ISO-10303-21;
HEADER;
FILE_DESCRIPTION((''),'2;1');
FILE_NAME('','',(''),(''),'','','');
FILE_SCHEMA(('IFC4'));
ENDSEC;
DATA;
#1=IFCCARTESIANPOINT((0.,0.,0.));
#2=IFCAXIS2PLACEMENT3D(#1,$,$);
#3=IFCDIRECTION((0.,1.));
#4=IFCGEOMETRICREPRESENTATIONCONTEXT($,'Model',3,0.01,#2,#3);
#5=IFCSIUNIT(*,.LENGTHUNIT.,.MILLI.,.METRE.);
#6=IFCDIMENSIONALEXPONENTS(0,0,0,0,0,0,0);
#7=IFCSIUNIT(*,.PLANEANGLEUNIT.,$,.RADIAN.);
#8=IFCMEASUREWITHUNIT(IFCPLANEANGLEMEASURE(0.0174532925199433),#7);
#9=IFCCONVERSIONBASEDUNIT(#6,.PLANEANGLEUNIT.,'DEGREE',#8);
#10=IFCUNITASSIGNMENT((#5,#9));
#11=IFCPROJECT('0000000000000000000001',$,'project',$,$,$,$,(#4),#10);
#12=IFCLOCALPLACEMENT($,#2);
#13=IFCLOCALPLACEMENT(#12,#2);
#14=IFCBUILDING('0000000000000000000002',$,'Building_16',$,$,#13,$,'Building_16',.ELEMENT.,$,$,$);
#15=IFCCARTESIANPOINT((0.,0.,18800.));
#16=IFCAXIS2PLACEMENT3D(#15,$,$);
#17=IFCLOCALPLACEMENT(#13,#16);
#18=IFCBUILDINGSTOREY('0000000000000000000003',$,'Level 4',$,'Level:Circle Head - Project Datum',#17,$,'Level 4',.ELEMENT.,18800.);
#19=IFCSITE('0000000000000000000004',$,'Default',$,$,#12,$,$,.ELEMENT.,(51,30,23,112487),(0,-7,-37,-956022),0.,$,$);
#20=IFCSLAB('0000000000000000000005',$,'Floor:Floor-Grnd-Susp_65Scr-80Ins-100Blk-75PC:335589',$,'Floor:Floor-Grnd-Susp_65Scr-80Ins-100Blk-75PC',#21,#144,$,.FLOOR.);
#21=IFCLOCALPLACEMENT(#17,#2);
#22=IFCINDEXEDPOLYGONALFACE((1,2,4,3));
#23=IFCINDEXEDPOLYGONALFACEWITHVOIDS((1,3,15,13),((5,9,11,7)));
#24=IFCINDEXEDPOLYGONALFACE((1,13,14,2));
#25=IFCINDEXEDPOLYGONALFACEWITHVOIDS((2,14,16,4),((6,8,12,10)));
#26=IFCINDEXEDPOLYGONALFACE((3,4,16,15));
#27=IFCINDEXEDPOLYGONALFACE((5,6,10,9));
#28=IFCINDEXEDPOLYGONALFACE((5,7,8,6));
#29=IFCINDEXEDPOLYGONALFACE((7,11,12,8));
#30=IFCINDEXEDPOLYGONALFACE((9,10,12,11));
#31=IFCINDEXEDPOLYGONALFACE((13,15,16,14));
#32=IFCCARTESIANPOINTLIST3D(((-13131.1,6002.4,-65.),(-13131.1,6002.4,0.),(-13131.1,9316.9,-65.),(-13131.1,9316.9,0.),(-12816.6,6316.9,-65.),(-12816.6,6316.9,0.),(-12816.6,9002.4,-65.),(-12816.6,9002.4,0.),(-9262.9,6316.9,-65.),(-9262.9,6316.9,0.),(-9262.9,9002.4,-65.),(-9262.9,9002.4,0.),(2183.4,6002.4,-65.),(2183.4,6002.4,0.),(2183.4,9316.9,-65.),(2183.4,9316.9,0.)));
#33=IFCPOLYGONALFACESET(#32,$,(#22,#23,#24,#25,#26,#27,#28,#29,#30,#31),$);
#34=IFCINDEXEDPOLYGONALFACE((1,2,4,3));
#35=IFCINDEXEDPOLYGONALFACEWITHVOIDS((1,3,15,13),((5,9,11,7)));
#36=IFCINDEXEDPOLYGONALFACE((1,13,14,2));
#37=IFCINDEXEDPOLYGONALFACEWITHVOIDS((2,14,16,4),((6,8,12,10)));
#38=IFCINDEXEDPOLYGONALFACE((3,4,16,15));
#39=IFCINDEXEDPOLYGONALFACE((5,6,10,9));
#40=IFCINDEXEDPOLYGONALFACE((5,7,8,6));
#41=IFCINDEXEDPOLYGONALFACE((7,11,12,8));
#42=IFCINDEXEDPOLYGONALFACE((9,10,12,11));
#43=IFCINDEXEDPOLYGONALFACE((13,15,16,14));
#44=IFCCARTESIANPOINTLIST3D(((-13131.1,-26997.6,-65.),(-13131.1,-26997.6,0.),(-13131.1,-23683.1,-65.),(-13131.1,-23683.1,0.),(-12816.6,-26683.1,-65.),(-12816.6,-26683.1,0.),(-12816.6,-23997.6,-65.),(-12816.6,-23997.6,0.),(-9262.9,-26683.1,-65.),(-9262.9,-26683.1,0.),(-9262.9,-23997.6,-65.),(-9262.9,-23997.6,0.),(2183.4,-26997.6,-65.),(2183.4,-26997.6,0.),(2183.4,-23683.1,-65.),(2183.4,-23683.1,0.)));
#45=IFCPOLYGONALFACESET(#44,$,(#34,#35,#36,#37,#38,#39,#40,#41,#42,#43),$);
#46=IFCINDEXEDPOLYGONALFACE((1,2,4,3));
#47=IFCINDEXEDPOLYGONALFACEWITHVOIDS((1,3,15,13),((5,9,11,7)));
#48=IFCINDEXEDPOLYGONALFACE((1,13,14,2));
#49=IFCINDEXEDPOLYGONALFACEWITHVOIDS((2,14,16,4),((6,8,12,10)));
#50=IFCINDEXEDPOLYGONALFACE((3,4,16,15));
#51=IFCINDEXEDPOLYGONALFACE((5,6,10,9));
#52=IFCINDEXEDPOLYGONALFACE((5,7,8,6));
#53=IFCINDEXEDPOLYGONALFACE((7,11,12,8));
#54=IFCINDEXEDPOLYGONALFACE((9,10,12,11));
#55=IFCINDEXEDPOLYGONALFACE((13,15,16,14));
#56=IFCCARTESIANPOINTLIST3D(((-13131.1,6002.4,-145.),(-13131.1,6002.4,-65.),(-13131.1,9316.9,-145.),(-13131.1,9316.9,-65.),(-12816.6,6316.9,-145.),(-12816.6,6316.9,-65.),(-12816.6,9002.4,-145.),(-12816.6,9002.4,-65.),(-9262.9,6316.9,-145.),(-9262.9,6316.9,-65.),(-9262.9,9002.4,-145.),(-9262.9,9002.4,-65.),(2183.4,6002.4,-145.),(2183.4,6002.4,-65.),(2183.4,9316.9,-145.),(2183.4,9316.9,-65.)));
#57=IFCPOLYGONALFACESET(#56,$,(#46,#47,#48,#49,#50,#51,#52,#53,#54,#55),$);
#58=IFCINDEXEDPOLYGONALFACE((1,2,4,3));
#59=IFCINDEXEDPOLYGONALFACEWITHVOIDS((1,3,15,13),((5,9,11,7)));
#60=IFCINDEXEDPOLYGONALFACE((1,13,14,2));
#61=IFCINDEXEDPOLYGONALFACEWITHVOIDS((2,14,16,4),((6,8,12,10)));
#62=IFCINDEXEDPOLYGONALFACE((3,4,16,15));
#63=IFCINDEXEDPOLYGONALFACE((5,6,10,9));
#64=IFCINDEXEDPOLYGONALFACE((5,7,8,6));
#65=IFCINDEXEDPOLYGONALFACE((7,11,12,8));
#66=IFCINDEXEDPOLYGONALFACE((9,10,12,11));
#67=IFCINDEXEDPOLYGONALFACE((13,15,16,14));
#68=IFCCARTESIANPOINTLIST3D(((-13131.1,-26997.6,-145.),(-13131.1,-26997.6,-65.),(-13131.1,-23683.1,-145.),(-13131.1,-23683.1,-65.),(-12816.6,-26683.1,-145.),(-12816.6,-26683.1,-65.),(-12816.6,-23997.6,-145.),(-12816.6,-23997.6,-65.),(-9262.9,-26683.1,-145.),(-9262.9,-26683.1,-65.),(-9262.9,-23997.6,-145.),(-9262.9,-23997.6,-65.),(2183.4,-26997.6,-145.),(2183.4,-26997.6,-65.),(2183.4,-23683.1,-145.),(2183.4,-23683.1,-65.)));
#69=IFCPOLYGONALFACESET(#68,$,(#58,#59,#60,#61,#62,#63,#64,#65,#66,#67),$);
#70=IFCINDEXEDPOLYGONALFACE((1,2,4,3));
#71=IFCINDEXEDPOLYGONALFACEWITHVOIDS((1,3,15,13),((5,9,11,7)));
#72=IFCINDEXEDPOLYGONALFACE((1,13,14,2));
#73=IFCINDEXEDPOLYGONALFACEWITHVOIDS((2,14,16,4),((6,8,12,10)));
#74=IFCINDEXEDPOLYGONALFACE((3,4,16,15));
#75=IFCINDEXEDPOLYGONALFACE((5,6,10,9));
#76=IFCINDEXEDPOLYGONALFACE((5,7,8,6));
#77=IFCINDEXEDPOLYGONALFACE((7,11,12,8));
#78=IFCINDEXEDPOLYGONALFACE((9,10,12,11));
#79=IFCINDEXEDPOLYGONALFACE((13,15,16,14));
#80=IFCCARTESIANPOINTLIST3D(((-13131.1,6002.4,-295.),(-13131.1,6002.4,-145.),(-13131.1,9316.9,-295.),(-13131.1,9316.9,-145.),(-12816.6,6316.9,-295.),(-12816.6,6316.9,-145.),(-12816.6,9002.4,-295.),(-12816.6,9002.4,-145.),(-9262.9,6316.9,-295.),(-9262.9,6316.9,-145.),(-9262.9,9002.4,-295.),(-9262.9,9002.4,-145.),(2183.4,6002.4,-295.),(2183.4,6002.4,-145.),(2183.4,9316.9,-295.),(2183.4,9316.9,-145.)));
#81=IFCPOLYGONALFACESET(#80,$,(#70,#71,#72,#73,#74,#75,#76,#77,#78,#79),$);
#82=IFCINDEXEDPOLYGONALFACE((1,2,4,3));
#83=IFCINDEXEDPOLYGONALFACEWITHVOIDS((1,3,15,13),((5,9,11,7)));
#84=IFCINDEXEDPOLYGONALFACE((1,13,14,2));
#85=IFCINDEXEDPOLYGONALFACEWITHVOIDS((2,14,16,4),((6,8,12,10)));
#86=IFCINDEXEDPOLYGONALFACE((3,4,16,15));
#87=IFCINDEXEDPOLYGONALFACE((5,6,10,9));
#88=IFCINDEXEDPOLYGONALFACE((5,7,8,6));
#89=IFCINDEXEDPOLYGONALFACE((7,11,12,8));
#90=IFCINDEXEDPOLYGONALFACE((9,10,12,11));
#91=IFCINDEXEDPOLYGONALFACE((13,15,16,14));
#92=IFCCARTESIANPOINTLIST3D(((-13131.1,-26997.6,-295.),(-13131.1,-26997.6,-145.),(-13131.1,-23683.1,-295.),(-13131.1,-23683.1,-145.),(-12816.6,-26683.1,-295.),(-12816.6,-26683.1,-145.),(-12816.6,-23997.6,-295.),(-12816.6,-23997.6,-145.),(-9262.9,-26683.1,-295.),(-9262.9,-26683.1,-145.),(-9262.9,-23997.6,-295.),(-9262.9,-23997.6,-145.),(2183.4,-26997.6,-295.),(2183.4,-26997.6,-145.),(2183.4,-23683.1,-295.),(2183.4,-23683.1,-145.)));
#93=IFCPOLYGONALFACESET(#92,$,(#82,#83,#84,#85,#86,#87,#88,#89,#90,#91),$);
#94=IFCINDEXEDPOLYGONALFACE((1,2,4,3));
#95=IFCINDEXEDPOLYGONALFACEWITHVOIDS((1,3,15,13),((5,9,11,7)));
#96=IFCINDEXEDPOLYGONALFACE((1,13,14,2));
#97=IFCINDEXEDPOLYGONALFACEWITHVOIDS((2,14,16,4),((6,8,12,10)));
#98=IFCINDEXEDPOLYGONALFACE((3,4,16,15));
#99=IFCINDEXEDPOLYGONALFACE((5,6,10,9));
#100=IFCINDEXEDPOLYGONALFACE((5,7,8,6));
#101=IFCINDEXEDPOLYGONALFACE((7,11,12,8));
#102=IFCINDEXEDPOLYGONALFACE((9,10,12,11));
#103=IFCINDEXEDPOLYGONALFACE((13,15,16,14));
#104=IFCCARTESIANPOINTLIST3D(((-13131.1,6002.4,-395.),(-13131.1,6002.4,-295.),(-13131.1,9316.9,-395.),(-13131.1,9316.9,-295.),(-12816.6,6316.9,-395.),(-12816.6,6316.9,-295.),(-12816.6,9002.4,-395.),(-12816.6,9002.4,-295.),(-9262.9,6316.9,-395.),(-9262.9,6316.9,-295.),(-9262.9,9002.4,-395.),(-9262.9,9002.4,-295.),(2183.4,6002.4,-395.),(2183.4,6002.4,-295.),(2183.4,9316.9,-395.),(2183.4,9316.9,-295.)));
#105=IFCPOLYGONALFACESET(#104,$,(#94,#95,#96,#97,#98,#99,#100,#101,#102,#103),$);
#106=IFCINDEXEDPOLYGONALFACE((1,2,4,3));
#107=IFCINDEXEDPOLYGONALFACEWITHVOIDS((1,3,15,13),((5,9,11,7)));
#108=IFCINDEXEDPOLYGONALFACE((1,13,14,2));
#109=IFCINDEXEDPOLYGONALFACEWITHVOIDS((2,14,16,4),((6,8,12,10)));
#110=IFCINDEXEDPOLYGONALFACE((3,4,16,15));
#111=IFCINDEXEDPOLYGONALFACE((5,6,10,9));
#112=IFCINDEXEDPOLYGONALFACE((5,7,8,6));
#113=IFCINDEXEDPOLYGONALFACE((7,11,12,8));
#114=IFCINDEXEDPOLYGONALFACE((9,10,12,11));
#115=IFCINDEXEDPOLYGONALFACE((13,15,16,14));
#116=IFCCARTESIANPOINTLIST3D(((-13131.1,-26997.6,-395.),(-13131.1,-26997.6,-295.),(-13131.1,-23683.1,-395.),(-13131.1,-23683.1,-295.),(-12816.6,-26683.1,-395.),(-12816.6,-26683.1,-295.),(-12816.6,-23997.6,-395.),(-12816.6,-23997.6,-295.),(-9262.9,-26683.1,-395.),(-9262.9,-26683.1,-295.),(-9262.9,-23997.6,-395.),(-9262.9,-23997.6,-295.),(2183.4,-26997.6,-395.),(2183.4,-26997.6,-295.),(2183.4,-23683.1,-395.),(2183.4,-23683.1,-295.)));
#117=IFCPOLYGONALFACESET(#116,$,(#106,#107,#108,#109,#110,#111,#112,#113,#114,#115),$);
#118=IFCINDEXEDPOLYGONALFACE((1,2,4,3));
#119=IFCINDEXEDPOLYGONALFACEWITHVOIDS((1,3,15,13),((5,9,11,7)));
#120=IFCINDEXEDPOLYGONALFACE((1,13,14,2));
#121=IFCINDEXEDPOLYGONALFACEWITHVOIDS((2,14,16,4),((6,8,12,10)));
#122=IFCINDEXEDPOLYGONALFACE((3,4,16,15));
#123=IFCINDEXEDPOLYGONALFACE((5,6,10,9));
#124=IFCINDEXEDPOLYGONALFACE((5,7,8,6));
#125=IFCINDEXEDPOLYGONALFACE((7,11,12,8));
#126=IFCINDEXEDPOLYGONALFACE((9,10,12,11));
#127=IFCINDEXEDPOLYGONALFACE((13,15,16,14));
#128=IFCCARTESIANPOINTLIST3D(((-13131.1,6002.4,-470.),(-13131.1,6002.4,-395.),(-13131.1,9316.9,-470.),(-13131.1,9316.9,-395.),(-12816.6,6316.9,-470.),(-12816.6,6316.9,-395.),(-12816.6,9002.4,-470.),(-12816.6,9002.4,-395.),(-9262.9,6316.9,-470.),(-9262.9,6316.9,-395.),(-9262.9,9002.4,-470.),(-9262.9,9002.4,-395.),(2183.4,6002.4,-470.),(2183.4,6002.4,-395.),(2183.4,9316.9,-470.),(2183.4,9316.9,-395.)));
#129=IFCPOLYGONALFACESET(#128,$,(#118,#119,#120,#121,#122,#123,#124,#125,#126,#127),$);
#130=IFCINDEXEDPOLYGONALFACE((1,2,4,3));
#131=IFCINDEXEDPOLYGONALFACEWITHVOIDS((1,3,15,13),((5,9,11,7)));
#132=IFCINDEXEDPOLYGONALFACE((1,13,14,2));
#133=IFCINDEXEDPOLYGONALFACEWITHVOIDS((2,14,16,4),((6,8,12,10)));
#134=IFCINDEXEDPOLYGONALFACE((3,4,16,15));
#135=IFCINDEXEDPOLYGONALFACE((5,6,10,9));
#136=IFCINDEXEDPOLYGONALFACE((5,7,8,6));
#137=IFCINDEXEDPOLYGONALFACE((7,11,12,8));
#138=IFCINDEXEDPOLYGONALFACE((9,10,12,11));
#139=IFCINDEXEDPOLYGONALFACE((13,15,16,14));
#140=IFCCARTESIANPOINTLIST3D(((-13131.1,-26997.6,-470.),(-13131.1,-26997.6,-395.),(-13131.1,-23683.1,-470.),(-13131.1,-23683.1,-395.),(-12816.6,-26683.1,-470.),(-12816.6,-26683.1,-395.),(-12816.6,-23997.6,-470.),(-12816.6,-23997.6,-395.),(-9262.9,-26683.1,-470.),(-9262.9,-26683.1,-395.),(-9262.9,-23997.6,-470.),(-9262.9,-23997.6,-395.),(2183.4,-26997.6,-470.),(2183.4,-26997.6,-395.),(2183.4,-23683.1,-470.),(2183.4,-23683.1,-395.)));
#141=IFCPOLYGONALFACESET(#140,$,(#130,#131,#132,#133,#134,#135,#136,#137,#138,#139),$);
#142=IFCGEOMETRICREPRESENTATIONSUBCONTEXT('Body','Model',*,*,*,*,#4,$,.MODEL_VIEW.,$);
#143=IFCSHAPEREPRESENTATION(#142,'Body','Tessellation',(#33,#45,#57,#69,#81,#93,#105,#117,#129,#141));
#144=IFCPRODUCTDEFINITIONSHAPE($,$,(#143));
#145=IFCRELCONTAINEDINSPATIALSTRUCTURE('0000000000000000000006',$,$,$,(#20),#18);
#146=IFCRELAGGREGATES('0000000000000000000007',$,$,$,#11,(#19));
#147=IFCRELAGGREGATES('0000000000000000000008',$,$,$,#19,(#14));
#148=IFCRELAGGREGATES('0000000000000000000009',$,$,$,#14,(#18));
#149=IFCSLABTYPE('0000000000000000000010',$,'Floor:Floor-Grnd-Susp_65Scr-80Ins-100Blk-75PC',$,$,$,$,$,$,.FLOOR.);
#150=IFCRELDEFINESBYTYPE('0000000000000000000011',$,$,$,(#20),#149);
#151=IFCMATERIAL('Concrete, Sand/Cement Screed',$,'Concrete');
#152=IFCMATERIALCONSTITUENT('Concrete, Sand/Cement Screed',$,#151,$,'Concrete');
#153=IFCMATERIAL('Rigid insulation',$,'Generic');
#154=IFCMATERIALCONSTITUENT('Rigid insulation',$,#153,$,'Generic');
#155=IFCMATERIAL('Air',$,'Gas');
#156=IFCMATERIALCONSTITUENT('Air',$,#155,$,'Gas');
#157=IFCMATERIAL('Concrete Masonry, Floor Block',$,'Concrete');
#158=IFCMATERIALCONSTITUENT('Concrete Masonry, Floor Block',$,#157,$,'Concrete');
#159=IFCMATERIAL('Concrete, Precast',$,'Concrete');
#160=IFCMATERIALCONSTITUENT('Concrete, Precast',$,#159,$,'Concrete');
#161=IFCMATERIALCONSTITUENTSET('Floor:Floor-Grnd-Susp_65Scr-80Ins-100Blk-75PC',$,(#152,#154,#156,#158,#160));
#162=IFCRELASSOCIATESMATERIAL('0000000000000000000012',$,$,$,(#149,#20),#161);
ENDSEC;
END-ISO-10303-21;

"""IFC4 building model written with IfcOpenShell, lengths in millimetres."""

from ifc_helpers import new_model, entity, si_unit, converted_unit, direction, frame, origin, place, context, subcontext, project, spatial, indexed_curve, outline, extrude, material, constituent, constituent_set, type_object, element, save


model = new_model("IFC4")

# Units and contexts
model_context = context("Model", 3, precision=0.01, world=origin(), true_north=direction((0.0, 1.0)))
body_context = subcontext(model_context, "Body", "Model", "MODEL_VIEW")
ifc_project = project(units=[si_unit("LENGTHUNIT", "METRE", prefix="MILLI"), converted_unit("PLANEANGLEUNIT", "DEGREE", entity("IfcPlaneAngleMeasure", 0.0174532925199433), si_unit("PLANEANGLEUNIT", "RADIAN"), dimensions=[0, 0, 0, 0, 0, 0, 0])], contexts=[model_context])

# Site, building, storey
site_placement = place(None, origin())
site = spatial("IfcSite", under=ifc_project, at=site_placement, Name="Default", CompositionType="ELEMENT", RefLatitude=(51, 30, 23, 112487), RefLongitude=(0, -7, -37, -956022), RefElevation=0.0)
building_placement = place(site_placement, origin())
building = spatial("IfcBuilding", under=site, at=building_placement, Name="Building_16", LongName="Building_16", CompositionType="ELEMENT")
storey_placement = place(building_placement, frame((0.0, 0.0, 18800.0)))
storey = spatial("IfcBuildingStorey", under=building, at=storey_placement, Name="Level 4", ObjectType="Level:Circle Head - Project Datum", LongName="Level 4", CompositionType="ELEMENT", Elevation=18800.0)

# Slab, openings
ifc_material_1 = material(Name="Concrete, Sand/Cement Screed", Category="Concrete")
ifc_constituent_1 = constituent(ifc_material_1, Name="Concrete, Sand/Cement Screed", Category="Concrete")
ifc_material_2 = material(Name="Rigid insulation", Category="Generic")
ifc_constituent_2 = constituent(ifc_material_2, Name="Rigid insulation", Category="Generic")
ifc_material_3 = material(Name="Air", Category="Gas")
ifc_constituent_3 = constituent(ifc_material_3, Name="Air", Category="Gas")
ifc_material_4 = material(Name="Concrete Masonry, Floor Block", Category="Concrete")
ifc_constituent_4 = constituent(ifc_material_4, Name="Concrete Masonry, Floor Block", Category="Concrete")
ifc_material_5 = material(Name="Concrete, Precast", Category="Concrete")
ifc_constituent_5 = constituent(ifc_material_5, Name="Concrete, Precast", Category="Concrete")
ifc_constituent_set_1 = constituent_set(constituents=[ifc_constituent_1, ifc_constituent_2, ifc_constituent_3, ifc_constituent_4, ifc_constituent_5], Name="Floor:Floor-Grnd-Susp_65Scr-80Ins-100Blk-75PC")
slab_type = type_object("IfcSlabType", Name="Floor:Floor-Grnd-Susp_65Scr-80Ins-100Blk-75PC", PredefinedType="FLOOR", material=ifc_constituent_set_1)
slab_placement = place(storey_placement, origin())
slab = element("IfcSlab", 1, at=slab_placement, inside=storey, type_object=slab_type, material=ifc_constituent_set_1, Name="Floor:Floor-Grnd-Susp_65Scr-80Ins-100Blk-75PC:335589", ObjectType="Floor:Floor-Grnd-Susp_65Scr-80Ins-100Blk-75PC", PredefinedType="FLOOR", context=body_context, shape_type="SweptSolid", body=[
    extrude(outline(indexed_curve([(-7657.2, -1657.3), (7657.2, -1657.3), (7657.2, 1657.3), (-7657.2, 1657.3), (-7657.2, -1657.3)], self_intersect=False), holes=[indexed_curve([(3789.0, -1342.8), (3789.0, 1342.8), (7342.8, 1342.8), (7342.8, -1342.8), (3789.0, -1342.8)], self_intersect=False)]), frame((-5473.9, 7659.6, -65.0), z_axis=(0.0, 0.0, 1.0), x_axis=(-1.0, 0.0, 0.0)), (0.0, 0.0, 1.0), 65.0),
    extrude(outline(indexed_curve([(-7657.2, -1657.2), (7657.2, -1657.2), (7657.2, 1657.2), (-7657.2, 1657.2), (-7657.2, -1657.2)], self_intersect=False), holes=[indexed_curve([(3789.0, -1342.7), (3789.0, 1342.7), (7342.8, 1342.7), (7342.8, -1342.7), (3789.0, -1342.7)], self_intersect=False)]), frame((-5473.9, -25340.4, -65.0), z_axis=(0.0, 0.0, 1.0), x_axis=(-1.0, 0.0, 0.0)), (0.0, 0.0, 1.0), 65.0),
    extrude(outline(indexed_curve([(-7657.2, -1657.3), (7657.2, -1657.3), (7657.2, 1657.3), (-7657.2, 1657.3), (-7657.2, -1657.3)], self_intersect=False), holes=[indexed_curve([(3789.0, -1342.8), (3789.0, 1342.8), (7342.8, 1342.8), (7342.8, -1342.8), (3789.0, -1342.8)], self_intersect=False)]), frame((-5473.9, 7659.6, -145.0), z_axis=(0.0, 0.0, 1.0), x_axis=(-1.0, 0.0, 0.0)), (0.0, 0.0, 1.0), 80.0),
    extrude(outline(indexed_curve([(-7657.2, -1657.2), (7657.2, -1657.2), (7657.2, 1657.2), (-7657.2, 1657.2), (-7657.2, -1657.2)], self_intersect=False), holes=[indexed_curve([(3789.0, -1342.7), (3789.0, 1342.7), (7342.8, 1342.7), (7342.8, -1342.7), (3789.0, -1342.7)], self_intersect=False)]), frame((-5473.9, -25340.4, -145.0), z_axis=(0.0, 0.0, 1.0), x_axis=(-1.0, 0.0, 0.0)), (0.0, 0.0, 1.0), 80.0),
    extrude(outline(indexed_curve([(-7657.2, -1657.3), (7657.2, -1657.3), (7657.2, 1657.3), (-7657.2, 1657.3), (-7657.2, -1657.3)], self_intersect=False), holes=[indexed_curve([(3789.0, -1342.8), (3789.0, 1342.8), (7342.8, 1342.8), (7342.8, -1342.8), (3789.0, -1342.8)], self_intersect=False)]), frame((-5473.9, 7659.6, -295.0), z_axis=(0.0, 0.0, 1.0), x_axis=(-1.0, 0.0, 0.0)), (0.0, 0.0, 1.0), 150.0),
    extrude(outline(indexed_curve([(-7657.2, -1657.2), (7657.2, -1657.2), (7657.2, 1657.2), (-7657.2, 1657.2), (-7657.2, -1657.2)], self_intersect=False), holes=[indexed_curve([(3789.0, -1342.7), (3789.0, 1342.7), (7342.8, 1342.7), (7342.8, -1342.7), (3789.0, -1342.7)], self_intersect=False)]), frame((-5473.9, -25340.4, -295.0), z_axis=(0.0, 0.0, 1.0), x_axis=(-1.0, 0.0, 0.0)), (0.0, 0.0, 1.0), 150.0),
    extrude(outline(indexed_curve([(-7657.2, -1657.3), (7657.2, -1657.3), (7657.2, 1657.3), (-7657.2, 1657.3), (-7657.2, -1657.3)], self_intersect=False), holes=[indexed_curve([(3789.0, -1342.8), (3789.0, 1342.8), (7342.8, 1342.8), (7342.8, -1342.8), (3789.0, -1342.8)], self_intersect=False)]), frame((-5473.9, 7659.6, -395.0), z_axis=(0.0, 0.0, 1.0), x_axis=(-1.0, 0.0, 0.0)), (0.0, 0.0, 1.0), 100.0),
    extrude(outline(indexed_curve([(-7657.2, -1657.2), (7657.2, -1657.2), (7657.2, 1657.2), (-7657.2, 1657.2), (-7657.2, -1657.2)], self_intersect=False), holes=[indexed_curve([(3789.0, -1342.7), (3789.0, 1342.7), (7342.8, 1342.7), (7342.8, -1342.7), (3789.0, -1342.7)], self_intersect=False)]), frame((-5473.9, -25340.4, -395.0), z_axis=(0.0, 0.0, 1.0), x_axis=(-1.0, 0.0, 0.0)), (0.0, 0.0, 1.0), 100.0),
    extrude(outline(indexed_curve([(-7657.2, -1657.3), (7657.2, -1657.3), (7657.2, 1657.3), (-7657.2, 1657.3), (-7657.2, -1657.3)], self_intersect=False), holes=[indexed_curve([(3789.0, -1342.8), (3789.0, 1342.8), (7342.8, 1342.8), (7342.8, -1342.8), (3789.0, -1342.8)], self_intersect=False)]), frame((-5473.9, 7659.6, -470.0), z_axis=(0.0, 0.0, 1.0), x_axis=(-1.0, 0.0, 0.0)), (0.0, 0.0, 1.0), 75.0),
    extrude(outline(indexed_curve([(-7657.2, -1657.2), (7657.2, -1657.2), (7657.2, 1657.2), (-7657.2, 1657.2), (-7657.2, -1657.2)], self_intersect=False), holes=[indexed_curve([(3789.0, -1342.7), (3789.0, 1342.7), (7342.8, 1342.7), (7342.8, -1342.7), (3789.0, -1342.7)], self_intersect=False)]), frame((-5473.9, -25340.4, -470.0), z_axis=(0.0, 0.0, 1.0), x_axis=(-1.0, 0.0, 0.0)), (0.0, 0.0, 1.0), 75.0),
])
opening_1_placement = place(slab_placement, origin())
element("IfcOpeningElement", 2, at=opening_1_placement, cuts=slab, PredefinedType="OPENING", context=body_context, shape_type="SweptSolid", body=[
    extrude(outline(indexed_curve([(-1342.7, 1776.9), (-1342.7, -1776.9), (1342.7, -1776.9), (1342.7, 1776.9), (-1342.7, 1776.9)], self_intersect=False)), frame((-11039.8, -25340.4, 0.0), z_axis=(0.0, 0.0, 1.0), x_axis=(0.0, -1.0, 0.0)), (0.0, 0.0, -1.0), 470.0),
])
opening_2_placement = place(slab_placement, origin())
element("IfcOpeningElement", 3, at=opening_2_placement, cuts=slab, PredefinedType="OPENING", context=body_context, shape_type="SweptSolid", body=[
    extrude(outline(indexed_curve([(-1342.8, -1776.9), (1342.8, -1776.9), (1342.8, 1776.9), (-1342.8, 1776.9), (-1342.8, -1776.9)], self_intersect=False)), frame((-11039.8, 7659.6, 0.0), z_axis=(0.0, 0.0, -1.0), x_axis=(0.0, -1.0, 0.0)), (0.0, 0.0, 1.0), 470.0),
])

save(model, "model.ifc")
